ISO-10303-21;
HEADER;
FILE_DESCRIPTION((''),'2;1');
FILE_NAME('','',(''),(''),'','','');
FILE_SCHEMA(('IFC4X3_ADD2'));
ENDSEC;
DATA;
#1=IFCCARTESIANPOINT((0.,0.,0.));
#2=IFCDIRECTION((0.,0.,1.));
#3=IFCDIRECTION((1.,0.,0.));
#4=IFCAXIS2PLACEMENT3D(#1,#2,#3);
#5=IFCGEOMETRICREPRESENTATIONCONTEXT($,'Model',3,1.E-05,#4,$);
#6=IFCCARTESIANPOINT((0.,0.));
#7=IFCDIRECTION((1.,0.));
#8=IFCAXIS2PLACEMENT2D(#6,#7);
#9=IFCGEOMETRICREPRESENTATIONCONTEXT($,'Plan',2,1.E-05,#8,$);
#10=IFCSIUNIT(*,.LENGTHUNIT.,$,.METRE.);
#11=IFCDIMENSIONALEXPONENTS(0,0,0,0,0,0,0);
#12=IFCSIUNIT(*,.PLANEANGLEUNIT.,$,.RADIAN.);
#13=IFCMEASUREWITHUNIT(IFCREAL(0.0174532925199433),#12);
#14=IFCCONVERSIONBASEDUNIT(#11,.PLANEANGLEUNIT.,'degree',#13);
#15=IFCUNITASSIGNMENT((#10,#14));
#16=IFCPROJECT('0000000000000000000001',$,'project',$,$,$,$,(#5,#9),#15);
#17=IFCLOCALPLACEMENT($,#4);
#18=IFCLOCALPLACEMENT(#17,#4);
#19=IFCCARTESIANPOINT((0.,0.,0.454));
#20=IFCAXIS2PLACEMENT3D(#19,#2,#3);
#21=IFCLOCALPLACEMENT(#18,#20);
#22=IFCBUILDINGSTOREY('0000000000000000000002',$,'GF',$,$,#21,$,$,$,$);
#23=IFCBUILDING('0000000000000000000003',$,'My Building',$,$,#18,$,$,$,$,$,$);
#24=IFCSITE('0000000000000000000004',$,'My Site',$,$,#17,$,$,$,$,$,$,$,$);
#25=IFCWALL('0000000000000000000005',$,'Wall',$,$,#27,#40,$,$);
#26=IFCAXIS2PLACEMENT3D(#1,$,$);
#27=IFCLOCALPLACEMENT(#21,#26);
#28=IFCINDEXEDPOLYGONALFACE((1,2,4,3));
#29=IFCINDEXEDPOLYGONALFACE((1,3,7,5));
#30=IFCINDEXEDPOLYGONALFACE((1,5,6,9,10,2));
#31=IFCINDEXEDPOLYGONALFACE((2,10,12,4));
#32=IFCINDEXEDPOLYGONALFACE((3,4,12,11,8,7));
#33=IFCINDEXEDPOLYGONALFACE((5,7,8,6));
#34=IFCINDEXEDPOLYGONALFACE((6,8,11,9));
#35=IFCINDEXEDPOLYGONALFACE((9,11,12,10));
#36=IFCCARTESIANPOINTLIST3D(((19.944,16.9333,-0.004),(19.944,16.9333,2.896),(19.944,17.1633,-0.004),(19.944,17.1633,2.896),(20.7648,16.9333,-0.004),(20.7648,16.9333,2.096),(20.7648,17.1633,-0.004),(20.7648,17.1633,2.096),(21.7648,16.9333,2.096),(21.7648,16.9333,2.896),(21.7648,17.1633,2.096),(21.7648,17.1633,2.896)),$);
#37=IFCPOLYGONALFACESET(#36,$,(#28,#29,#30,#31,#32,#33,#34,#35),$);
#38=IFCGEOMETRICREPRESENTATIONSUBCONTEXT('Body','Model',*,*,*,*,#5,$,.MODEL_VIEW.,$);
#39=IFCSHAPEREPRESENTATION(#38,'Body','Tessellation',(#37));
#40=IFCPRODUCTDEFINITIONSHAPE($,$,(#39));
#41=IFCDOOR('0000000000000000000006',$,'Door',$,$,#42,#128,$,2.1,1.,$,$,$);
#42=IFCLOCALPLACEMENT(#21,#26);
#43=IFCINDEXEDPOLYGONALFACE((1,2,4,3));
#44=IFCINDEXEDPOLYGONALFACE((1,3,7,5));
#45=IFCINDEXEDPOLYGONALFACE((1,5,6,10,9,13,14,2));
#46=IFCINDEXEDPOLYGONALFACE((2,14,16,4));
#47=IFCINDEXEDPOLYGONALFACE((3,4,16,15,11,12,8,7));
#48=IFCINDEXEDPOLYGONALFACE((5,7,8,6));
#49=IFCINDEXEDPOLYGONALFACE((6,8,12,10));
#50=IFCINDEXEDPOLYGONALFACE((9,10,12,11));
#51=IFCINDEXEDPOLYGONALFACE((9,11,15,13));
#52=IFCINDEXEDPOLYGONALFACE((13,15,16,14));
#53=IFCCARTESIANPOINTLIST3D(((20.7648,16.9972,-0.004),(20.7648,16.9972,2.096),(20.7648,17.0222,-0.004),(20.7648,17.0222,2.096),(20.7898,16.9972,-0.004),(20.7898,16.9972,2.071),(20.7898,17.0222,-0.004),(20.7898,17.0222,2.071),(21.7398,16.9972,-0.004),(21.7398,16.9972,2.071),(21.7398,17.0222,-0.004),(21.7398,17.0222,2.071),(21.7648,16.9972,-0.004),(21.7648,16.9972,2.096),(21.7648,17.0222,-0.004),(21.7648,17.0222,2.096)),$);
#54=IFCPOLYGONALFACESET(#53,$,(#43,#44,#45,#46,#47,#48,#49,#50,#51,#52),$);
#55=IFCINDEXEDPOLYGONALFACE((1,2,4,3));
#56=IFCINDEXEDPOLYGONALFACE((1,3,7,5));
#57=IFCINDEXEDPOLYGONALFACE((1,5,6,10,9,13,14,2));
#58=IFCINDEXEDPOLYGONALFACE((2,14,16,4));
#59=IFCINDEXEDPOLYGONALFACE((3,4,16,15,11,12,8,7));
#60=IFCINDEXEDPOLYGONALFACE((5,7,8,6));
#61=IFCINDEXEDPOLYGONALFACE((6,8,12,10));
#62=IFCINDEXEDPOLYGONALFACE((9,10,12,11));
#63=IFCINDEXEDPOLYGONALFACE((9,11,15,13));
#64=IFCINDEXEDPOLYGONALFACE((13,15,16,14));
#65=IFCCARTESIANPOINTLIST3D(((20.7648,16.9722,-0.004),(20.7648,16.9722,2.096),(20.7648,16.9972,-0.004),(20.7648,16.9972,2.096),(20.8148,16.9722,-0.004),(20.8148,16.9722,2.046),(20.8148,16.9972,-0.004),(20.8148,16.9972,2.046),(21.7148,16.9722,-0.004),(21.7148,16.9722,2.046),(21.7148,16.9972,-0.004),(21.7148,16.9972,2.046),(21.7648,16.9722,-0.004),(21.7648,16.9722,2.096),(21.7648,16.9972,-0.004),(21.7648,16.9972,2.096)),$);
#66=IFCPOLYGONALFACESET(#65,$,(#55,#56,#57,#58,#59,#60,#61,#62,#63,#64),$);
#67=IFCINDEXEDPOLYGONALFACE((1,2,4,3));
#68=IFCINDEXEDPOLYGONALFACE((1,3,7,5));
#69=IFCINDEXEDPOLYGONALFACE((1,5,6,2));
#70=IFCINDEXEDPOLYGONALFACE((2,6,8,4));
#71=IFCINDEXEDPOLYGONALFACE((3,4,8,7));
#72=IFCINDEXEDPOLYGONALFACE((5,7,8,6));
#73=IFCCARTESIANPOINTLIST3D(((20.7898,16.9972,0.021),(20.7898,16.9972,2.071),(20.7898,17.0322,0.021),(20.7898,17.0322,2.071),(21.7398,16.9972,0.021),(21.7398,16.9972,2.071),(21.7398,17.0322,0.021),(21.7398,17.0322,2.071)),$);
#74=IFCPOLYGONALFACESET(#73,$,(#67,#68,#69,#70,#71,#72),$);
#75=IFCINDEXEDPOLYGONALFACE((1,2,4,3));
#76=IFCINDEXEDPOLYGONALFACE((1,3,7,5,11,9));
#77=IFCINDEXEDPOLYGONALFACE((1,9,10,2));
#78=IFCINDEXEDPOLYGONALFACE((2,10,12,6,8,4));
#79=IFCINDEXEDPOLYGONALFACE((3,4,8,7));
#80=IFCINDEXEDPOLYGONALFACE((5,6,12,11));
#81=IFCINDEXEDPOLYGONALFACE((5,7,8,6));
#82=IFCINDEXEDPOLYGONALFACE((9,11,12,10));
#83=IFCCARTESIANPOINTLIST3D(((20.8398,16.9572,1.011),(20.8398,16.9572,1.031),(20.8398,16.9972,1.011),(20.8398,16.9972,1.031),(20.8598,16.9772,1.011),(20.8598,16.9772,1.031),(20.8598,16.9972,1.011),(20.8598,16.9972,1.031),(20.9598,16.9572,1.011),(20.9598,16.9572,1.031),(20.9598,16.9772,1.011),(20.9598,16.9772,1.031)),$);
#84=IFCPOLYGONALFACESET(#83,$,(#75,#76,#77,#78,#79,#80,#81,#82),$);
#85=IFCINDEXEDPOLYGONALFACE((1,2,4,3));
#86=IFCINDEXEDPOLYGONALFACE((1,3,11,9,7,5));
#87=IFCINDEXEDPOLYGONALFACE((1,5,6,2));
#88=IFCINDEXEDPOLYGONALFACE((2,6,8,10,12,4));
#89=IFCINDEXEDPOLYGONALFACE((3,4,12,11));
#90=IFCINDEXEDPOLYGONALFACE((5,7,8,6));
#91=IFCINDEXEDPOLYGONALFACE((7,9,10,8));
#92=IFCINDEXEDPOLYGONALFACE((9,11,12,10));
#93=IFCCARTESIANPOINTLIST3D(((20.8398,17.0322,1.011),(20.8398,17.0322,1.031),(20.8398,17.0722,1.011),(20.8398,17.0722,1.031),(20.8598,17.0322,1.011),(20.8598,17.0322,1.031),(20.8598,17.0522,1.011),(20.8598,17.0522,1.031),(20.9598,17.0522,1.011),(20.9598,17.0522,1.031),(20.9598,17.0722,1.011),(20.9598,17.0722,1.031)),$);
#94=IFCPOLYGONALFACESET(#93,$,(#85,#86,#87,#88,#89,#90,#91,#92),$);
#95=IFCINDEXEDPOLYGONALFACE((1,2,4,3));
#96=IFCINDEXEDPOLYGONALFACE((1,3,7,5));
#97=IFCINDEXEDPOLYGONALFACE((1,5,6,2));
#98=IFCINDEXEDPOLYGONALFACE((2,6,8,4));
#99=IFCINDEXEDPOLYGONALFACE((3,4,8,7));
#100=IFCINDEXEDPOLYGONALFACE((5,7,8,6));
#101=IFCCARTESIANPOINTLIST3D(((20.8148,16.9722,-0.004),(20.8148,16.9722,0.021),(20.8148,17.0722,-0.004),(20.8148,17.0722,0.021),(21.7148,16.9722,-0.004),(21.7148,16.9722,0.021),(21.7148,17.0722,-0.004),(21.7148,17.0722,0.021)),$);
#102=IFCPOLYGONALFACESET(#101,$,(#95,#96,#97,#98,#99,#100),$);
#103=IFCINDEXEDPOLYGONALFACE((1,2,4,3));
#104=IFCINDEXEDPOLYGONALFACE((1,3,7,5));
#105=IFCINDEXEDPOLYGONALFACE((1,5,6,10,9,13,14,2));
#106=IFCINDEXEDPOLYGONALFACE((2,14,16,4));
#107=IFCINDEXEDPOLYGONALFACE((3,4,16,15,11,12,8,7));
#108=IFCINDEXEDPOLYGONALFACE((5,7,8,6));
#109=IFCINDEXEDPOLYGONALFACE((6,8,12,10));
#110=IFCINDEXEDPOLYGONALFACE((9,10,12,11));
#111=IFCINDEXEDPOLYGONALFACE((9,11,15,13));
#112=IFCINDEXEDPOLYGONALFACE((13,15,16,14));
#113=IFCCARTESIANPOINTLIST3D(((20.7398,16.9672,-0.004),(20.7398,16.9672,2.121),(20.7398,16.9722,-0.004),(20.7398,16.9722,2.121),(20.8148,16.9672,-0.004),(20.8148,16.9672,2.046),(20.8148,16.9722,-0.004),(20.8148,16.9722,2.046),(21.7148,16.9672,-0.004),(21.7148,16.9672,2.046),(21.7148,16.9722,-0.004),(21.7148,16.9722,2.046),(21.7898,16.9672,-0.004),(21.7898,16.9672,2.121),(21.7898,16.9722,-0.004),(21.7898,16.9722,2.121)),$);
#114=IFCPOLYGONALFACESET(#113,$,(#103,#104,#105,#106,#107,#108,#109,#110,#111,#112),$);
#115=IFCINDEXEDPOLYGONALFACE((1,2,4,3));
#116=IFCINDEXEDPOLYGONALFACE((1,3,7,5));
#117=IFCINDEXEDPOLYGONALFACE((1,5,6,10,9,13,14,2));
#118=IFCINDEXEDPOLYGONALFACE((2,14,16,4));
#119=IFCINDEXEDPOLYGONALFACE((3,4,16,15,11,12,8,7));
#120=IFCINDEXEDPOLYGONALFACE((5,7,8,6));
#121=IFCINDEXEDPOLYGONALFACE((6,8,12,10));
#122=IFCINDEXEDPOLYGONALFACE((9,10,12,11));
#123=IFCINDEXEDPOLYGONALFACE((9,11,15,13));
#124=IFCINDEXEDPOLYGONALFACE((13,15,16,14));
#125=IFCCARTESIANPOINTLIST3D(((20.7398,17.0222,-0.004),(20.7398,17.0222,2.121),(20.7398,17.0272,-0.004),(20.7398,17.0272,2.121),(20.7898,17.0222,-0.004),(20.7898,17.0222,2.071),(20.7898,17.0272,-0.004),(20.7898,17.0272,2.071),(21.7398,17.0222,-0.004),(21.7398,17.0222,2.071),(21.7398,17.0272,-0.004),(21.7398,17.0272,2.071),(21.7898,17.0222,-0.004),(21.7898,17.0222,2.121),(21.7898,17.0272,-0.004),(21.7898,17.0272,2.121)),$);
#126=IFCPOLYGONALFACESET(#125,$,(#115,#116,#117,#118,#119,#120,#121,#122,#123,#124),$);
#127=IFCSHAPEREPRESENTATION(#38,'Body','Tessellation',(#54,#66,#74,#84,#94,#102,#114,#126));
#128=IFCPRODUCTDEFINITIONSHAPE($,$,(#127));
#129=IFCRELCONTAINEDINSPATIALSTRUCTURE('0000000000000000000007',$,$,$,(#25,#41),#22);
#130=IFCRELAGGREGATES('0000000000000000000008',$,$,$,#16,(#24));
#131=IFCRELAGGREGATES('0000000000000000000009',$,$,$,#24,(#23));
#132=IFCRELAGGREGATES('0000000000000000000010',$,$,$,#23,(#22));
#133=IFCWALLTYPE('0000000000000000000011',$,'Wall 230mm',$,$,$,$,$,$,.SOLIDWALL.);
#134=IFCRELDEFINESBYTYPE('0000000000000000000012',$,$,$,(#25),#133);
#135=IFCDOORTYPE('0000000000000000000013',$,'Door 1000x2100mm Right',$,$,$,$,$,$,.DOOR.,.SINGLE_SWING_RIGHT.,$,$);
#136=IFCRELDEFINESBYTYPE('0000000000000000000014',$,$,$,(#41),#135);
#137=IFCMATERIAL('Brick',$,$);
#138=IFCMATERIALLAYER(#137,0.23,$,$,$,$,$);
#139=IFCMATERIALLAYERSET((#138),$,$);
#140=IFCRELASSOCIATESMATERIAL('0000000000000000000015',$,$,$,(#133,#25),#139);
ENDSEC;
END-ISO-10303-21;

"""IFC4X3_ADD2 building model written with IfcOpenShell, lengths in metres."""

from ifc_helpers import new_model, entity, si_unit, converted_unit, frame, origin_with_axes, origin_2d_with_axis, place, context, subcontext, project, spatial, line, indexed_curve, outline, extrude, shape, source, transform, mapped, material, layer, layer_set, layer_usage, type_object, type_shapes, element, fill, save


model = new_model("IFC4X3_ADD2")

# Units and contexts
model_context = context("Model", 3, precision=1e-05, world=origin_with_axes())
plan_context = context("Plan", 2, precision=1e-05, world=origin_2d_with_axis())
body_context_1 = subcontext(model_context, "Body", "Model", "MODEL_VIEW")
body_context_2 = subcontext(plan_context, "Body", "Plan", "PLAN_VIEW")
ifc_project = project(units=[si_unit("LENGTHUNIT", "METRE"), converted_unit("PLANEANGLEUNIT", "degree", entity("IfcReal", 0.0174532925199433), si_unit("PLANEANGLEUNIT", "RADIAN"), dimensions=[0, 0, 0, 0, 0, 0, 0])], contexts=[model_context, plan_context])

# Site, building, storey
site_placement = place(None, origin_with_axes())
site = spatial("IfcSite", under=ifc_project, at=site_placement, Name="My Site")
building_placement = place(site_placement, origin_with_axes())
building = spatial("IfcBuilding", under=site, at=building_placement, Name="My Building")
storey_placement = place(building_placement, frame((0.0, 0.0, 0.454), z_axis=(0.0, 0.0, 1.0), x_axis=(1.0, 0.0, 0.0)))
storey = spatial("IfcBuildingStorey", under=building, at=storey_placement, Name="GF")

# Shared definitions
ifc_material_1 = material(Name="Brick")
ifc_layer_1 = layer(ifc_material_1, 0.23)
ifc_layer_set_1 = layer_set([ifc_layer_1])
wall_type = type_object("IfcWallType", Name="Wall 230mm", PredefinedType="SOLIDWALL", material=ifc_layer_set_1)

# Wall, opening, door
ifc_layer_usage_1 = layer_usage(ifc_layer_set_1, "AXIS2", "POSITIVE", 0.0)
wall_1_placement = place(storey_placement, frame((21.7648, 17.1633, -0.004), z_axis=(0.0, 0.0, 1.0), x_axis=(-1.0, 0.0, 0.0)))
wall_1 = element("IfcWall", 1, at=wall_1_placement, inside=storey, type_object=wall_type, material=ifc_layer_usage_1, Name="Wall", context=body_context_1, shape_type="SweptSolid", body=[
    extrude(outline(indexed_curve([(0.0, 0.0), (0.0, 0.23), (1.8208, 0.23), (1.8208, 0.0), (0.0, 0.0)], self_intersect=False)), origin_with_axes(), (0.0, 0.0, 1.0), 2.9),
])
shared_shape_1 = source(origin_with_axes(), body_context_1, "Body", "SweptSolid", [
    extrude(outline(indexed_curve([(0.0, 0.0), (1.0, 0.0), (1.0, 2.1), (0.0, 2.1)], segments=[line(1, 2, 3, 4, 1)])), frame((0.0, -0.6, 0.0), z_axis=(0.0, -1.0, 0.0), x_axis=(1.0, 0.0, 0.0)), (0.0, 0.0, -1.0), 1.2),
])
opening_1_placement = place(wall_1_placement, frame((1.0, 0.1911, 0.0), z_axis=(0.0, 0.0, 1.0), x_axis=(-1.0, 0.0, 0.0)))
opening_1 = element("IfcOpeningElement", 2, at=opening_1_placement, cuts=wall_1, PredefinedType="OPENING", context=body_context_1, shape_type="MappedRepresentation", body=[
    mapped(shared_shape_1, transform((0.0, 0.0, 0.0), x_axis=(1.0, 0.0, 0.0), y_axis=(0.0, 1.0, 0.0), z_axis=(0.0, 0.0, 1.0), scale=1.0)),
])
door_type_1 = type_object("IfcDoorType", Name="Door 1000x2100mm Right", OperationType="SINGLE_SWING_RIGHT", PredefinedType="DOOR")
shared_shape_2 = source(origin_with_axes(), body_context_1, "Body", "SweptSolid", [
    extrude(outline(indexed_curve([(0.0, 0.0), (0.0, 2.1), (1.0, 2.1), (1.0, 0.0), (0.975, 0.0), (0.975, 2.075), (0.025, 2.075), (0.025, 0.0)], segments=[line(1, 2, 3, 4, 5, 6, 7, 8, 1)])), frame((0.0, 0.025, 0.0), z_axis=(0.0, -1.0, 0.0), x_axis=(1.0, 0.0, 0.0)), (0.0, 0.0, -1.0), 0.025),
    extrude(outline(indexed_curve([(0.0, 0.0), (0.0, 2.1), (1.0, 2.1), (1.0, 0.0), (0.95, 0.0), (0.95, 2.05), (0.05, 2.05), (0.05, 0.0)], segments=[line(1, 2, 3, 4, 5, 6, 7, 8, 1)])), frame((0.0, 0.0, 0.0), z_axis=(0.0, -1.0, 0.0), x_axis=(1.0, 0.0, 0.0)), (0.0, 0.0, -1.0), 0.025),
    extrude(outline(indexed_curve([(0.0, 0.0), (0.95, 0.0), (0.95, 0.035), (0.0, 0.035)], segments=[line(1, 2, 3, 4, 1)])), frame((0.025, 0.025, 0.025), z_axis=(0.0, 0.0, 1.0), x_axis=(1.0, 0.0, 0.0)), (0.0, 0.0, 1.0), 2.05),
    extrude(outline(indexed_curve([(0.0, 0.0), (0.0, -0.04), (0.12, -0.04), (0.12, -0.02), (0.02, -0.02), (0.02, 0.0)], segments=[line(1, 2, 3, 4, 5, 6, 1)])), frame((0.075, 0.025, 1.015), z_axis=(0.0, 0.0, 1.0), x_axis=(1.0, 0.0, 0.0)), (0.0, 0.0, 1.0), 0.02),
    extrude(outline(indexed_curve([(0.0, 0.0), (0.0, 0.04), (0.12, 0.04), (0.12, 0.02), (0.02, 0.02), (0.02, 0.0)], segments=[line(1, 2, 3, 4, 5, 6, 1)])), frame((0.075, 0.06, 1.015), z_axis=(0.0, 0.0, 1.0), x_axis=(1.0, 0.0, 0.0)), (0.0, 0.0, 1.0), 0.02),
    extrude(outline(indexed_curve([(0.0, 0.0), (0.9, 0.0), (0.9, 0.1), (0.0, 0.1)], segments=[line(1, 2, 3, 4, 1)])), frame((0.05, 0.0, 0.0), z_axis=(0.0, 0.0, 1.0), x_axis=(1.0, 0.0, 0.0)), (0.0, 0.0, 1.0), 0.025),
    extrude(outline(indexed_curve([(0.0, 0.0), (0.0, 2.125), (1.05, 2.125), (1.05, 0.0), (0.975, 0.0), (0.975, 2.05), (0.075, 2.05), (0.075, 0.0)], segments=[line(1, 2, 3, 4, 5, 6, 7, 8, 1)])), frame((-0.025, -0.005, 0.0), z_axis=(0.0, -1.0, 0.0), x_axis=(1.0, 0.0, 0.0)), (0.0, 0.0, -1.0), 0.005),
    extrude(outline(indexed_curve([(0.0, 0.0), (0.0, 2.125), (1.05, 2.125), (1.05, 0.0), (1.0, 0.0), (1.0, 2.075), (0.05, 2.075), (0.05, 0.0)], segments=[line(1, 2, 3, 4, 5, 6, 7, 8, 1)])), frame((-0.025, 0.05, 0.0), z_axis=(0.0, -1.0, 0.0), x_axis=(1.0, 0.0, 0.0)), (0.0, 0.0, -1.0), 0.005),
])
shared_shape_3 = source(origin_with_axes(), body_context_2, "Body", "Curve2D", [
    entity("IfcIndexedPolyCurve", entity("IfcCartesianPointList2D", [[0.0, 0.0], [0.0, 0.05], [0.025, 0.05], [0.025, 0.025], [0.05, 0.025], [0.05, 0.0]]), [entity("IfcLineIndex", [1, 2, 3, 4, 5, 6, 1])]),
    entity("IfcIndexedPolyCurve", entity("IfcCartesianPointList2D", [[1.0, 0.0], [1.0, 0.05], [0.975, 0.05], [0.975, 0.025], [0.95, 0.025], [0.95, 0.0]]), [entity("IfcLineIndex", [1, 2, 3, 4, 5, 6, 1])]),
    entity("IfcTrimmedCurve", entity("IfcEllipse", entity("IfcAxis2Placement2D", entity("IfcCartesianPoint", [0.94, 0.05]), entity("IfcDirection", [1.0, 0.0])), 0.915, 0.95), [entity("IfcCartesianPoint", [0.94, 1.0])], [entity("IfcCartesianPoint", [0.025, 0.05])], True, "CARTESIAN"),
    entity("IfcIndexedPolyCurve", entity("IfcCartesianPointList2D", [[0.975, 0.05], [0.94, 0.05], [0.94, 1.0], [0.975, 1.0]]), [entity("IfcLineIndex", [1, 2, 3, 4, 1])]),
])
type_shapes(door_type_1, [shared_shape_2, shared_shape_3])
door_1_placement = place(opening_1_placement, frame((0.0, 0.0, 0.0), z_axis=(0.0, 0.0, 1.0), x_axis=(1.0, 0.0, 0.0)))
door_1 = element("IfcDoor", 3, at=door_1_placement, inside=storey, type_object=door_type_1, Name="Door", OverallHeight=2.1, OverallWidth=1.0, shapes=[
    shape(body_context_1, "Body", "MappedRepresentation", [mapped(shared_shape_2, transform((0.0, 0.0, 0.0), x_axis=(1.0, 0.0, 0.0), y_axis=(0.0, 1.0, 0.0), z_axis=(0.0, 0.0, 1.0), scale=1.0))]),
    shape(body_context_2, "Body", "MappedRepresentation", [mapped(shared_shape_3, transform((0.0, 0.0, 0.0), x_axis=(1.0, 0.0, 0.0), y_axis=(0.0, 1.0, 0.0), z_axis=(0.0, 0.0, 1.0), scale=1.0))]),
])
fill(opening_1, door_1)

save(model, "model.ifc")
